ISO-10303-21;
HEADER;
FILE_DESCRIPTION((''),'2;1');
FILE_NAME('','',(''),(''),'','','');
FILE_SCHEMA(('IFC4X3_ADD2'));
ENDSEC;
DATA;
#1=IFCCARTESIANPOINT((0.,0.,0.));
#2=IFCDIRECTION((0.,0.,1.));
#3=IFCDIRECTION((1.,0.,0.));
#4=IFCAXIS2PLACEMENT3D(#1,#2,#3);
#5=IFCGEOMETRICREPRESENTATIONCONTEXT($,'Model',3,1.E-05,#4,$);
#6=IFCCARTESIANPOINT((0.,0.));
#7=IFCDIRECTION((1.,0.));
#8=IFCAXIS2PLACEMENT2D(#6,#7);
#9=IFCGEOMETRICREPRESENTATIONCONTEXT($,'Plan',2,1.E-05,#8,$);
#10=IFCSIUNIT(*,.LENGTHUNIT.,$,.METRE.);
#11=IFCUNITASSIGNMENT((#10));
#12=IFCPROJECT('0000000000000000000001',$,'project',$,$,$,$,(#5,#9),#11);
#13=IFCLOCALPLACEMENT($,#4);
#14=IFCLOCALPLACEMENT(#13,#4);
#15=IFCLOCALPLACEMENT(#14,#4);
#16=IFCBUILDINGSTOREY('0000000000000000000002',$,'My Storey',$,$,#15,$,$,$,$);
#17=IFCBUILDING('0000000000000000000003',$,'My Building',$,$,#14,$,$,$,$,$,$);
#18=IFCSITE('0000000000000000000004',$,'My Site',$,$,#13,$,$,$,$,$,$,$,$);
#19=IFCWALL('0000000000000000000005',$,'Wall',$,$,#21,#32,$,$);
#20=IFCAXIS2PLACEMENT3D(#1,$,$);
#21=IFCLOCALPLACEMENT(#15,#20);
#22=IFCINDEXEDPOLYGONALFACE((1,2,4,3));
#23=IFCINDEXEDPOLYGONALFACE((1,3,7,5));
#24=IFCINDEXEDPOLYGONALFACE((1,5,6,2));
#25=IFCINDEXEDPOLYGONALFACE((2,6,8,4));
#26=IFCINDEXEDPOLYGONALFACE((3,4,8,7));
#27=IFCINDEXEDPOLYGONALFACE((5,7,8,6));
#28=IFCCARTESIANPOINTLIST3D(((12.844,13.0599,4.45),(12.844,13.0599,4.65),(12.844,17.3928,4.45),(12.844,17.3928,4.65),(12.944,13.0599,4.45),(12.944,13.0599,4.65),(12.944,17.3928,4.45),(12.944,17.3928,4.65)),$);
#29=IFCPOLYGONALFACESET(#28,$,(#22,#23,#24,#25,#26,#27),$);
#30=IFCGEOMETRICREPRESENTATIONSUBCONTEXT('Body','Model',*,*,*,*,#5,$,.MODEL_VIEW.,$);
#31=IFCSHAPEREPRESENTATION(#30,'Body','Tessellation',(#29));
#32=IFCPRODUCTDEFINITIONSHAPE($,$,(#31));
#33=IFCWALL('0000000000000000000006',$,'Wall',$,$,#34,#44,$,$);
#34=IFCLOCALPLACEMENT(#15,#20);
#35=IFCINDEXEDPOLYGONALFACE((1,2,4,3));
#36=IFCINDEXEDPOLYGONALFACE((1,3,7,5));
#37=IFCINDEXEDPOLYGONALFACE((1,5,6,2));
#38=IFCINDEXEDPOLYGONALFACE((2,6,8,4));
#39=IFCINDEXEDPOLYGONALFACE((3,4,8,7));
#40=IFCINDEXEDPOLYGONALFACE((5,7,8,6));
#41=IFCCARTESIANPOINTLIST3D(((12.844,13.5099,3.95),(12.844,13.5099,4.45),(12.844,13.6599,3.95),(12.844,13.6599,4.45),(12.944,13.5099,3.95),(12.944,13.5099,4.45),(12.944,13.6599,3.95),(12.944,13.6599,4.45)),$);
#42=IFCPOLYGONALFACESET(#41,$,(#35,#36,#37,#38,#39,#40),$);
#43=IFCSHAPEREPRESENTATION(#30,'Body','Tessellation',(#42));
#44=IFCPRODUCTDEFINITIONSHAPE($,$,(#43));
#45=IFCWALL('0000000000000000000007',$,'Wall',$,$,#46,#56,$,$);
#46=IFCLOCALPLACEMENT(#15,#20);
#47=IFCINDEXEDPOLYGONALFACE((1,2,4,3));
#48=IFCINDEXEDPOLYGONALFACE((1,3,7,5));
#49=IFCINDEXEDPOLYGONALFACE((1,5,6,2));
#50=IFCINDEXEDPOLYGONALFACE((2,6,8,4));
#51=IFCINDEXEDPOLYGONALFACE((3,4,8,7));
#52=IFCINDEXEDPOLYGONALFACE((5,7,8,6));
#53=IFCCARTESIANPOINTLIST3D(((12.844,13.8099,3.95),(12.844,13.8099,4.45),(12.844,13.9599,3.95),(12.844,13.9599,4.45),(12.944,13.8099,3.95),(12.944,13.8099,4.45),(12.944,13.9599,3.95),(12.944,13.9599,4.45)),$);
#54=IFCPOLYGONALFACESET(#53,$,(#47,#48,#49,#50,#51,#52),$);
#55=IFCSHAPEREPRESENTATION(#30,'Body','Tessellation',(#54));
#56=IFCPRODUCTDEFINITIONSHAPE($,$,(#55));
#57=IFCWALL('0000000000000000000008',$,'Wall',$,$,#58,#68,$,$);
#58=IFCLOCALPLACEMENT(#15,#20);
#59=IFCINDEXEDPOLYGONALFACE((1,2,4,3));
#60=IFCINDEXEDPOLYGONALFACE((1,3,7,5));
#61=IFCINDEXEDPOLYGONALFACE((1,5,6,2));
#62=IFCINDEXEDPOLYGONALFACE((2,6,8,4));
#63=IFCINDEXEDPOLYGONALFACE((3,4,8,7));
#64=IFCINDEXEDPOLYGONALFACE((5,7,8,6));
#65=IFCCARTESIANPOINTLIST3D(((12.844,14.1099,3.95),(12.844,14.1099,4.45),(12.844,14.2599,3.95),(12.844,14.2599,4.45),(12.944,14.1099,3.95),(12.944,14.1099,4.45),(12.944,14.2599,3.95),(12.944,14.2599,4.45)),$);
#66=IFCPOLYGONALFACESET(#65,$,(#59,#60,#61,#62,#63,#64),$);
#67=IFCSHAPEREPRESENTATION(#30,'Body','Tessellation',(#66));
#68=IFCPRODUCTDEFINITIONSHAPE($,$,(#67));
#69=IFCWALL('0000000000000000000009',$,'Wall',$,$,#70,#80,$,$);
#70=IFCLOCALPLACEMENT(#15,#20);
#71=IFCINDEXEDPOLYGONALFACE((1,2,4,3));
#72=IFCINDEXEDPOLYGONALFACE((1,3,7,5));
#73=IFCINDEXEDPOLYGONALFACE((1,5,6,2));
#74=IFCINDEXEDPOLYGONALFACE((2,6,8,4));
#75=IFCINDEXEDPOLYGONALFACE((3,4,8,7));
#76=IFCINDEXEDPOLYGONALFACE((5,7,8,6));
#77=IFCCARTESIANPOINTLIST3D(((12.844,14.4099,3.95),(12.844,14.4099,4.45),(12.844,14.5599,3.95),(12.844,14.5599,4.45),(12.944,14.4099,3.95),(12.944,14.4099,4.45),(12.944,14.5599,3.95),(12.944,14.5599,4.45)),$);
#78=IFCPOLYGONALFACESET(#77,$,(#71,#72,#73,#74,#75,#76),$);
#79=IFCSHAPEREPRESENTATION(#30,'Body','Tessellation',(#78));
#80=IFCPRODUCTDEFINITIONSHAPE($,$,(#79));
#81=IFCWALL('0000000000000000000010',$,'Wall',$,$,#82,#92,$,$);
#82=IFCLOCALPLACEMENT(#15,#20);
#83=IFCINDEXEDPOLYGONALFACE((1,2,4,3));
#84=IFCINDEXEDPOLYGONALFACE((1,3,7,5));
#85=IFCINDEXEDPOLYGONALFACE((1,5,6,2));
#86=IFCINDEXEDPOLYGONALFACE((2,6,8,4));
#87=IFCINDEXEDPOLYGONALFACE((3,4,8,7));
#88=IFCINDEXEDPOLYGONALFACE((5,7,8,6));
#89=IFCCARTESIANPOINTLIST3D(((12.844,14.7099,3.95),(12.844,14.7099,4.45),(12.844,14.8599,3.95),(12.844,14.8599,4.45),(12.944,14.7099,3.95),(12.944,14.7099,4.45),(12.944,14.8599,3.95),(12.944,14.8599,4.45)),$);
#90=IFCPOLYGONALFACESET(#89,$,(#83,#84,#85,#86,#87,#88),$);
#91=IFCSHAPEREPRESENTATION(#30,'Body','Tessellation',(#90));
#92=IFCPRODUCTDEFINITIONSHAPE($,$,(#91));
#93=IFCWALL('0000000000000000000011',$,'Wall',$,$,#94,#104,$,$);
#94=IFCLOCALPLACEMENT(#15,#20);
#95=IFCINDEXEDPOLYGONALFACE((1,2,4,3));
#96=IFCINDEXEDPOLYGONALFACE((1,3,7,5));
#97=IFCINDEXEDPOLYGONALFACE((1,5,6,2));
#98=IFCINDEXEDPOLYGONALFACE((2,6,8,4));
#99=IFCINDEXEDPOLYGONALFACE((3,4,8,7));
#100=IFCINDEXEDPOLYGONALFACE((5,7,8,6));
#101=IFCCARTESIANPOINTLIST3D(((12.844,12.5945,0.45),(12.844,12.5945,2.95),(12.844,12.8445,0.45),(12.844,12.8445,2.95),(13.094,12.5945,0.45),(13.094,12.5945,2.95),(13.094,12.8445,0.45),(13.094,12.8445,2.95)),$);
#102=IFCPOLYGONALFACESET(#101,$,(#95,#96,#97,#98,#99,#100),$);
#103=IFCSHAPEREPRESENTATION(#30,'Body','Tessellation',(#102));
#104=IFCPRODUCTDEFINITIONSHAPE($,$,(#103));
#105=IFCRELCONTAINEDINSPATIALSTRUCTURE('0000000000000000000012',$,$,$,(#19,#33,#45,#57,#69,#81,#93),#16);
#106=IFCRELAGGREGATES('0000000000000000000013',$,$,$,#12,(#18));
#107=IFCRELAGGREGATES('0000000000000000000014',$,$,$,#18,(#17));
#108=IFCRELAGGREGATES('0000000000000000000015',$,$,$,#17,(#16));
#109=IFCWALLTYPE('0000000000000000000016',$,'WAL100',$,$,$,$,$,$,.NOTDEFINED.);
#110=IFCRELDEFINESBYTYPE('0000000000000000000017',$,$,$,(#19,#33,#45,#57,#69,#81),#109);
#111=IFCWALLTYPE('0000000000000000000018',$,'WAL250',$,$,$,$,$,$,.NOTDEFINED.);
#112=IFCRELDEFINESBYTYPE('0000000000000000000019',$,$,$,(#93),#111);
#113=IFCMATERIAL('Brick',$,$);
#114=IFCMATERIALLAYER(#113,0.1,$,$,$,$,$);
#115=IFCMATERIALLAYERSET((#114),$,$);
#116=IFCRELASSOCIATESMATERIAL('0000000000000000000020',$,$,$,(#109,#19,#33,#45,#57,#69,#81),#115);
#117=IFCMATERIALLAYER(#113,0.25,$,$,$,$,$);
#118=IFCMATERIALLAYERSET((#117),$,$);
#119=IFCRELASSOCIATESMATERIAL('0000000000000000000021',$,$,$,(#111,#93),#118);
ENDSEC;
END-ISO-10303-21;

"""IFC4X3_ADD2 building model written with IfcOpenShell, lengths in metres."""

from ifc_helpers import new_model, si_unit, frame, origin_with_axes, origin_2d_with_axis, place, context, subcontext, project, spatial, line, indexed_curve, outline, extrude, material, layer, layer_set, layer_usage, type_object, element, save


model = new_model("IFC4X3_ADD2")

# Units and contexts
model_context = context("Model", 3, precision=1e-05, world=origin_with_axes())
plan_context = context("Plan", 2, precision=1e-05, world=origin_2d_with_axis())
body_context = subcontext(model_context, "Body", "Model", "MODEL_VIEW")
ifc_project = project(units=[si_unit("LENGTHUNIT", "METRE")], contexts=[model_context, plan_context])

# Site, building, storey
site_placement = place(None, origin_with_axes())
site = spatial("IfcSite", under=ifc_project, at=site_placement, Name="My Site")
building_placement = place(site_placement, origin_with_axes())
building = spatial("IfcBuilding", under=site, at=building_placement, Name="My Building")
storey_placement = place(building_placement, origin_with_axes())
storey = spatial("IfcBuildingStorey", under=building, at=storey_placement, Name="My Storey")

# Walls
ifc_material_1 = material(Name="Brick")
ifc_layer_1 = layer(ifc_material_1, 0.1)
ifc_layer_set_1 = layer_set([ifc_layer_1])
wall_type_1 = type_object("IfcWallType", Name="WAL100", PredefinedType="NOTDEFINED", material=ifc_layer_set_1)
ifc_layer_usage_1 = layer_usage(ifc_layer_set_1, "AXIS2", "POSITIVE", 0.0)
wall_1_placement = place(storey_placement, frame((12.944, 13.0599, 4.45), z_axis=(0.0, 0.0, 1.0), x_axis=(-0.000005, 1.0, 0.0)))
element("IfcWall", 1, at=wall_1_placement, inside=storey, type_object=wall_type_1, material=ifc_layer_usage_1, Name="Wall", context=body_context, shape_type="SweptSolid", body=[
    extrude(outline(indexed_curve([(0.0, 0.0), (0.0, 0.1), (4.3329, 0.1), (4.3329, 0.0)], segments=[line(1, 2, 3, 4, 1)])), origin_with_axes(), (0.0, 0.0, 1.0), 0.2),
])
ifc_layer_usage_2 = layer_usage(ifc_layer_set_1, "AXIS2", "POSITIVE", 0.0)
wall_2_placement = place(storey_placement, frame((12.944, 13.5099, 3.95), z_axis=(0.0, 0.0, 1.0), x_axis=(-0.000005, 1.0, 0.0)))
element("IfcWall", 2, at=wall_2_placement, inside=storey, type_object=wall_type_1, material=ifc_layer_usage_2, Name="Wall", context=body_context, shape_type="SweptSolid", body=[
    extrude(outline(indexed_curve([(0.0, 0.0), (0.0, 0.1), (0.15, 0.1), (0.15, 0.0)], segments=[line(1, 2, 3, 4, 1)])), origin_with_axes(), (0.0, 0.0, 1.0), 0.5),
])
ifc_layer_usage_3 = layer_usage(ifc_layer_set_1, "AXIS2", "POSITIVE", 0.0)
wall_3_placement = place(storey_placement, frame((12.944, 13.8099, 3.95), z_axis=(0.0, 0.0, 1.0), x_axis=(-0.000005, 1.0, 0.0)))
element("IfcWall", 3, at=wall_3_placement, inside=storey, type_object=wall_type_1, material=ifc_layer_usage_3, Name="Wall", context=body_context, shape_type="SweptSolid", body=[
    extrude(outline(indexed_curve([(0.0, 0.0), (0.0, 0.1), (0.15, 0.1), (0.15, 0.0)], segments=[line(1, 2, 3, 4, 1)])), origin_with_axes(), (0.0, 0.0, 1.0), 0.5),
])
ifc_layer_usage_4 = layer_usage(ifc_layer_set_1, "AXIS2", "POSITIVE", 0.0)
wall_4_placement = place(storey_placement, frame((12.944, 14.1099, 3.95), z_axis=(0.0, 0.0, 1.0), x_axis=(-0.000005, 1.0, 0.0)))
element("IfcWall", 4, at=wall_4_placement, inside=storey, type_object=wall_type_1, material=ifc_layer_usage_4, Name="Wall", context=body_context, shape_type="SweptSolid", body=[
    extrude(outline(indexed_curve([(0.0, 0.0), (0.0, 0.1), (0.15, 0.1), (0.15, 0.0)], segments=[line(1, 2, 3, 4, 1)])), origin_with_axes(), (0.0, 0.0, 1.0), 0.5),
])
ifc_layer_usage_5 = layer_usage(ifc_layer_set_1, "AXIS2", "POSITIVE", 0.0)
wall_5_placement = place(storey_placement, frame((12.944, 14.4099, 3.95), z_axis=(0.0, 0.0, 1.0), x_axis=(-0.000005, 1.0, 0.0)))
element("IfcWall", 5, at=wall_5_placement, inside=storey, type_object=wall_type_1, material=ifc_layer_usage_5, Name="Wall", context=body_context, shape_type="SweptSolid", body=[
    extrude(outline(indexed_curve([(0.0, 0.0), (0.0, 0.1), (0.15, 0.1), (0.15, 0.0)], segments=[line(1, 2, 3, 4, 1)])), origin_with_axes(), (0.0, 0.0, 1.0), 0.5),
])
ifc_layer_usage_6 = layer_usage(ifc_layer_set_1, "AXIS2", "POSITIVE", 0.0)
wall_6_placement = place(storey_placement, frame((12.944, 14.7099, 3.95), z_axis=(0.0, 0.0, 1.0), x_axis=(-0.000005, 1.0, 0.0)))
element("IfcWall", 6, at=wall_6_placement, inside=storey, type_object=wall_type_1, material=ifc_layer_usage_6, Name="Wall", context=body_context, shape_type="SweptSolid", body=[
    extrude(outline(indexed_curve([(0.0, 0.0), (0.0, 0.1), (0.15, 0.1), (0.15, 0.0)], segments=[line(1, 2, 3, 4, 1)])), origin_with_axes(), (0.0, 0.0, 1.0), 0.5),
])
ifc_layer_2 = layer(ifc_material_1, 0.25)
ifc_layer_set_2 = layer_set([ifc_layer_2])
ifc_layer_usage_7 = layer_usage(ifc_layer_set_2, "AXIS2", "NEGATIVE", 0.0)
wall_type_2 = type_object("IfcWallType", Name="WAL250", PredefinedType="NOTDEFINED", material=ifc_layer_set_2)
wall_7_placement = place(storey_placement, frame((12.844, 12.5945, 0.45), z_axis=(0.0, 0.0, 1.0), x_axis=(-0.000005, 1.0, 0.0)))
element("IfcWall", 7, at=wall_7_placement, inside=storey, type_object=wall_type_2, material=ifc_layer_usage_7, Name="Wall", context=body_context, shape_type="SweptSolid", body=[
    extrude(outline(indexed_curve([(0.0, -0.25), (0.0, 0.0), (0.25, 0.0), (0.25, -0.25)], segments=[line(1, 2, 3, 4, 1)])), origin_with_axes(), (0.0, 0.0, 1.0), 2.5),
])

save(model, "model.ifc")
